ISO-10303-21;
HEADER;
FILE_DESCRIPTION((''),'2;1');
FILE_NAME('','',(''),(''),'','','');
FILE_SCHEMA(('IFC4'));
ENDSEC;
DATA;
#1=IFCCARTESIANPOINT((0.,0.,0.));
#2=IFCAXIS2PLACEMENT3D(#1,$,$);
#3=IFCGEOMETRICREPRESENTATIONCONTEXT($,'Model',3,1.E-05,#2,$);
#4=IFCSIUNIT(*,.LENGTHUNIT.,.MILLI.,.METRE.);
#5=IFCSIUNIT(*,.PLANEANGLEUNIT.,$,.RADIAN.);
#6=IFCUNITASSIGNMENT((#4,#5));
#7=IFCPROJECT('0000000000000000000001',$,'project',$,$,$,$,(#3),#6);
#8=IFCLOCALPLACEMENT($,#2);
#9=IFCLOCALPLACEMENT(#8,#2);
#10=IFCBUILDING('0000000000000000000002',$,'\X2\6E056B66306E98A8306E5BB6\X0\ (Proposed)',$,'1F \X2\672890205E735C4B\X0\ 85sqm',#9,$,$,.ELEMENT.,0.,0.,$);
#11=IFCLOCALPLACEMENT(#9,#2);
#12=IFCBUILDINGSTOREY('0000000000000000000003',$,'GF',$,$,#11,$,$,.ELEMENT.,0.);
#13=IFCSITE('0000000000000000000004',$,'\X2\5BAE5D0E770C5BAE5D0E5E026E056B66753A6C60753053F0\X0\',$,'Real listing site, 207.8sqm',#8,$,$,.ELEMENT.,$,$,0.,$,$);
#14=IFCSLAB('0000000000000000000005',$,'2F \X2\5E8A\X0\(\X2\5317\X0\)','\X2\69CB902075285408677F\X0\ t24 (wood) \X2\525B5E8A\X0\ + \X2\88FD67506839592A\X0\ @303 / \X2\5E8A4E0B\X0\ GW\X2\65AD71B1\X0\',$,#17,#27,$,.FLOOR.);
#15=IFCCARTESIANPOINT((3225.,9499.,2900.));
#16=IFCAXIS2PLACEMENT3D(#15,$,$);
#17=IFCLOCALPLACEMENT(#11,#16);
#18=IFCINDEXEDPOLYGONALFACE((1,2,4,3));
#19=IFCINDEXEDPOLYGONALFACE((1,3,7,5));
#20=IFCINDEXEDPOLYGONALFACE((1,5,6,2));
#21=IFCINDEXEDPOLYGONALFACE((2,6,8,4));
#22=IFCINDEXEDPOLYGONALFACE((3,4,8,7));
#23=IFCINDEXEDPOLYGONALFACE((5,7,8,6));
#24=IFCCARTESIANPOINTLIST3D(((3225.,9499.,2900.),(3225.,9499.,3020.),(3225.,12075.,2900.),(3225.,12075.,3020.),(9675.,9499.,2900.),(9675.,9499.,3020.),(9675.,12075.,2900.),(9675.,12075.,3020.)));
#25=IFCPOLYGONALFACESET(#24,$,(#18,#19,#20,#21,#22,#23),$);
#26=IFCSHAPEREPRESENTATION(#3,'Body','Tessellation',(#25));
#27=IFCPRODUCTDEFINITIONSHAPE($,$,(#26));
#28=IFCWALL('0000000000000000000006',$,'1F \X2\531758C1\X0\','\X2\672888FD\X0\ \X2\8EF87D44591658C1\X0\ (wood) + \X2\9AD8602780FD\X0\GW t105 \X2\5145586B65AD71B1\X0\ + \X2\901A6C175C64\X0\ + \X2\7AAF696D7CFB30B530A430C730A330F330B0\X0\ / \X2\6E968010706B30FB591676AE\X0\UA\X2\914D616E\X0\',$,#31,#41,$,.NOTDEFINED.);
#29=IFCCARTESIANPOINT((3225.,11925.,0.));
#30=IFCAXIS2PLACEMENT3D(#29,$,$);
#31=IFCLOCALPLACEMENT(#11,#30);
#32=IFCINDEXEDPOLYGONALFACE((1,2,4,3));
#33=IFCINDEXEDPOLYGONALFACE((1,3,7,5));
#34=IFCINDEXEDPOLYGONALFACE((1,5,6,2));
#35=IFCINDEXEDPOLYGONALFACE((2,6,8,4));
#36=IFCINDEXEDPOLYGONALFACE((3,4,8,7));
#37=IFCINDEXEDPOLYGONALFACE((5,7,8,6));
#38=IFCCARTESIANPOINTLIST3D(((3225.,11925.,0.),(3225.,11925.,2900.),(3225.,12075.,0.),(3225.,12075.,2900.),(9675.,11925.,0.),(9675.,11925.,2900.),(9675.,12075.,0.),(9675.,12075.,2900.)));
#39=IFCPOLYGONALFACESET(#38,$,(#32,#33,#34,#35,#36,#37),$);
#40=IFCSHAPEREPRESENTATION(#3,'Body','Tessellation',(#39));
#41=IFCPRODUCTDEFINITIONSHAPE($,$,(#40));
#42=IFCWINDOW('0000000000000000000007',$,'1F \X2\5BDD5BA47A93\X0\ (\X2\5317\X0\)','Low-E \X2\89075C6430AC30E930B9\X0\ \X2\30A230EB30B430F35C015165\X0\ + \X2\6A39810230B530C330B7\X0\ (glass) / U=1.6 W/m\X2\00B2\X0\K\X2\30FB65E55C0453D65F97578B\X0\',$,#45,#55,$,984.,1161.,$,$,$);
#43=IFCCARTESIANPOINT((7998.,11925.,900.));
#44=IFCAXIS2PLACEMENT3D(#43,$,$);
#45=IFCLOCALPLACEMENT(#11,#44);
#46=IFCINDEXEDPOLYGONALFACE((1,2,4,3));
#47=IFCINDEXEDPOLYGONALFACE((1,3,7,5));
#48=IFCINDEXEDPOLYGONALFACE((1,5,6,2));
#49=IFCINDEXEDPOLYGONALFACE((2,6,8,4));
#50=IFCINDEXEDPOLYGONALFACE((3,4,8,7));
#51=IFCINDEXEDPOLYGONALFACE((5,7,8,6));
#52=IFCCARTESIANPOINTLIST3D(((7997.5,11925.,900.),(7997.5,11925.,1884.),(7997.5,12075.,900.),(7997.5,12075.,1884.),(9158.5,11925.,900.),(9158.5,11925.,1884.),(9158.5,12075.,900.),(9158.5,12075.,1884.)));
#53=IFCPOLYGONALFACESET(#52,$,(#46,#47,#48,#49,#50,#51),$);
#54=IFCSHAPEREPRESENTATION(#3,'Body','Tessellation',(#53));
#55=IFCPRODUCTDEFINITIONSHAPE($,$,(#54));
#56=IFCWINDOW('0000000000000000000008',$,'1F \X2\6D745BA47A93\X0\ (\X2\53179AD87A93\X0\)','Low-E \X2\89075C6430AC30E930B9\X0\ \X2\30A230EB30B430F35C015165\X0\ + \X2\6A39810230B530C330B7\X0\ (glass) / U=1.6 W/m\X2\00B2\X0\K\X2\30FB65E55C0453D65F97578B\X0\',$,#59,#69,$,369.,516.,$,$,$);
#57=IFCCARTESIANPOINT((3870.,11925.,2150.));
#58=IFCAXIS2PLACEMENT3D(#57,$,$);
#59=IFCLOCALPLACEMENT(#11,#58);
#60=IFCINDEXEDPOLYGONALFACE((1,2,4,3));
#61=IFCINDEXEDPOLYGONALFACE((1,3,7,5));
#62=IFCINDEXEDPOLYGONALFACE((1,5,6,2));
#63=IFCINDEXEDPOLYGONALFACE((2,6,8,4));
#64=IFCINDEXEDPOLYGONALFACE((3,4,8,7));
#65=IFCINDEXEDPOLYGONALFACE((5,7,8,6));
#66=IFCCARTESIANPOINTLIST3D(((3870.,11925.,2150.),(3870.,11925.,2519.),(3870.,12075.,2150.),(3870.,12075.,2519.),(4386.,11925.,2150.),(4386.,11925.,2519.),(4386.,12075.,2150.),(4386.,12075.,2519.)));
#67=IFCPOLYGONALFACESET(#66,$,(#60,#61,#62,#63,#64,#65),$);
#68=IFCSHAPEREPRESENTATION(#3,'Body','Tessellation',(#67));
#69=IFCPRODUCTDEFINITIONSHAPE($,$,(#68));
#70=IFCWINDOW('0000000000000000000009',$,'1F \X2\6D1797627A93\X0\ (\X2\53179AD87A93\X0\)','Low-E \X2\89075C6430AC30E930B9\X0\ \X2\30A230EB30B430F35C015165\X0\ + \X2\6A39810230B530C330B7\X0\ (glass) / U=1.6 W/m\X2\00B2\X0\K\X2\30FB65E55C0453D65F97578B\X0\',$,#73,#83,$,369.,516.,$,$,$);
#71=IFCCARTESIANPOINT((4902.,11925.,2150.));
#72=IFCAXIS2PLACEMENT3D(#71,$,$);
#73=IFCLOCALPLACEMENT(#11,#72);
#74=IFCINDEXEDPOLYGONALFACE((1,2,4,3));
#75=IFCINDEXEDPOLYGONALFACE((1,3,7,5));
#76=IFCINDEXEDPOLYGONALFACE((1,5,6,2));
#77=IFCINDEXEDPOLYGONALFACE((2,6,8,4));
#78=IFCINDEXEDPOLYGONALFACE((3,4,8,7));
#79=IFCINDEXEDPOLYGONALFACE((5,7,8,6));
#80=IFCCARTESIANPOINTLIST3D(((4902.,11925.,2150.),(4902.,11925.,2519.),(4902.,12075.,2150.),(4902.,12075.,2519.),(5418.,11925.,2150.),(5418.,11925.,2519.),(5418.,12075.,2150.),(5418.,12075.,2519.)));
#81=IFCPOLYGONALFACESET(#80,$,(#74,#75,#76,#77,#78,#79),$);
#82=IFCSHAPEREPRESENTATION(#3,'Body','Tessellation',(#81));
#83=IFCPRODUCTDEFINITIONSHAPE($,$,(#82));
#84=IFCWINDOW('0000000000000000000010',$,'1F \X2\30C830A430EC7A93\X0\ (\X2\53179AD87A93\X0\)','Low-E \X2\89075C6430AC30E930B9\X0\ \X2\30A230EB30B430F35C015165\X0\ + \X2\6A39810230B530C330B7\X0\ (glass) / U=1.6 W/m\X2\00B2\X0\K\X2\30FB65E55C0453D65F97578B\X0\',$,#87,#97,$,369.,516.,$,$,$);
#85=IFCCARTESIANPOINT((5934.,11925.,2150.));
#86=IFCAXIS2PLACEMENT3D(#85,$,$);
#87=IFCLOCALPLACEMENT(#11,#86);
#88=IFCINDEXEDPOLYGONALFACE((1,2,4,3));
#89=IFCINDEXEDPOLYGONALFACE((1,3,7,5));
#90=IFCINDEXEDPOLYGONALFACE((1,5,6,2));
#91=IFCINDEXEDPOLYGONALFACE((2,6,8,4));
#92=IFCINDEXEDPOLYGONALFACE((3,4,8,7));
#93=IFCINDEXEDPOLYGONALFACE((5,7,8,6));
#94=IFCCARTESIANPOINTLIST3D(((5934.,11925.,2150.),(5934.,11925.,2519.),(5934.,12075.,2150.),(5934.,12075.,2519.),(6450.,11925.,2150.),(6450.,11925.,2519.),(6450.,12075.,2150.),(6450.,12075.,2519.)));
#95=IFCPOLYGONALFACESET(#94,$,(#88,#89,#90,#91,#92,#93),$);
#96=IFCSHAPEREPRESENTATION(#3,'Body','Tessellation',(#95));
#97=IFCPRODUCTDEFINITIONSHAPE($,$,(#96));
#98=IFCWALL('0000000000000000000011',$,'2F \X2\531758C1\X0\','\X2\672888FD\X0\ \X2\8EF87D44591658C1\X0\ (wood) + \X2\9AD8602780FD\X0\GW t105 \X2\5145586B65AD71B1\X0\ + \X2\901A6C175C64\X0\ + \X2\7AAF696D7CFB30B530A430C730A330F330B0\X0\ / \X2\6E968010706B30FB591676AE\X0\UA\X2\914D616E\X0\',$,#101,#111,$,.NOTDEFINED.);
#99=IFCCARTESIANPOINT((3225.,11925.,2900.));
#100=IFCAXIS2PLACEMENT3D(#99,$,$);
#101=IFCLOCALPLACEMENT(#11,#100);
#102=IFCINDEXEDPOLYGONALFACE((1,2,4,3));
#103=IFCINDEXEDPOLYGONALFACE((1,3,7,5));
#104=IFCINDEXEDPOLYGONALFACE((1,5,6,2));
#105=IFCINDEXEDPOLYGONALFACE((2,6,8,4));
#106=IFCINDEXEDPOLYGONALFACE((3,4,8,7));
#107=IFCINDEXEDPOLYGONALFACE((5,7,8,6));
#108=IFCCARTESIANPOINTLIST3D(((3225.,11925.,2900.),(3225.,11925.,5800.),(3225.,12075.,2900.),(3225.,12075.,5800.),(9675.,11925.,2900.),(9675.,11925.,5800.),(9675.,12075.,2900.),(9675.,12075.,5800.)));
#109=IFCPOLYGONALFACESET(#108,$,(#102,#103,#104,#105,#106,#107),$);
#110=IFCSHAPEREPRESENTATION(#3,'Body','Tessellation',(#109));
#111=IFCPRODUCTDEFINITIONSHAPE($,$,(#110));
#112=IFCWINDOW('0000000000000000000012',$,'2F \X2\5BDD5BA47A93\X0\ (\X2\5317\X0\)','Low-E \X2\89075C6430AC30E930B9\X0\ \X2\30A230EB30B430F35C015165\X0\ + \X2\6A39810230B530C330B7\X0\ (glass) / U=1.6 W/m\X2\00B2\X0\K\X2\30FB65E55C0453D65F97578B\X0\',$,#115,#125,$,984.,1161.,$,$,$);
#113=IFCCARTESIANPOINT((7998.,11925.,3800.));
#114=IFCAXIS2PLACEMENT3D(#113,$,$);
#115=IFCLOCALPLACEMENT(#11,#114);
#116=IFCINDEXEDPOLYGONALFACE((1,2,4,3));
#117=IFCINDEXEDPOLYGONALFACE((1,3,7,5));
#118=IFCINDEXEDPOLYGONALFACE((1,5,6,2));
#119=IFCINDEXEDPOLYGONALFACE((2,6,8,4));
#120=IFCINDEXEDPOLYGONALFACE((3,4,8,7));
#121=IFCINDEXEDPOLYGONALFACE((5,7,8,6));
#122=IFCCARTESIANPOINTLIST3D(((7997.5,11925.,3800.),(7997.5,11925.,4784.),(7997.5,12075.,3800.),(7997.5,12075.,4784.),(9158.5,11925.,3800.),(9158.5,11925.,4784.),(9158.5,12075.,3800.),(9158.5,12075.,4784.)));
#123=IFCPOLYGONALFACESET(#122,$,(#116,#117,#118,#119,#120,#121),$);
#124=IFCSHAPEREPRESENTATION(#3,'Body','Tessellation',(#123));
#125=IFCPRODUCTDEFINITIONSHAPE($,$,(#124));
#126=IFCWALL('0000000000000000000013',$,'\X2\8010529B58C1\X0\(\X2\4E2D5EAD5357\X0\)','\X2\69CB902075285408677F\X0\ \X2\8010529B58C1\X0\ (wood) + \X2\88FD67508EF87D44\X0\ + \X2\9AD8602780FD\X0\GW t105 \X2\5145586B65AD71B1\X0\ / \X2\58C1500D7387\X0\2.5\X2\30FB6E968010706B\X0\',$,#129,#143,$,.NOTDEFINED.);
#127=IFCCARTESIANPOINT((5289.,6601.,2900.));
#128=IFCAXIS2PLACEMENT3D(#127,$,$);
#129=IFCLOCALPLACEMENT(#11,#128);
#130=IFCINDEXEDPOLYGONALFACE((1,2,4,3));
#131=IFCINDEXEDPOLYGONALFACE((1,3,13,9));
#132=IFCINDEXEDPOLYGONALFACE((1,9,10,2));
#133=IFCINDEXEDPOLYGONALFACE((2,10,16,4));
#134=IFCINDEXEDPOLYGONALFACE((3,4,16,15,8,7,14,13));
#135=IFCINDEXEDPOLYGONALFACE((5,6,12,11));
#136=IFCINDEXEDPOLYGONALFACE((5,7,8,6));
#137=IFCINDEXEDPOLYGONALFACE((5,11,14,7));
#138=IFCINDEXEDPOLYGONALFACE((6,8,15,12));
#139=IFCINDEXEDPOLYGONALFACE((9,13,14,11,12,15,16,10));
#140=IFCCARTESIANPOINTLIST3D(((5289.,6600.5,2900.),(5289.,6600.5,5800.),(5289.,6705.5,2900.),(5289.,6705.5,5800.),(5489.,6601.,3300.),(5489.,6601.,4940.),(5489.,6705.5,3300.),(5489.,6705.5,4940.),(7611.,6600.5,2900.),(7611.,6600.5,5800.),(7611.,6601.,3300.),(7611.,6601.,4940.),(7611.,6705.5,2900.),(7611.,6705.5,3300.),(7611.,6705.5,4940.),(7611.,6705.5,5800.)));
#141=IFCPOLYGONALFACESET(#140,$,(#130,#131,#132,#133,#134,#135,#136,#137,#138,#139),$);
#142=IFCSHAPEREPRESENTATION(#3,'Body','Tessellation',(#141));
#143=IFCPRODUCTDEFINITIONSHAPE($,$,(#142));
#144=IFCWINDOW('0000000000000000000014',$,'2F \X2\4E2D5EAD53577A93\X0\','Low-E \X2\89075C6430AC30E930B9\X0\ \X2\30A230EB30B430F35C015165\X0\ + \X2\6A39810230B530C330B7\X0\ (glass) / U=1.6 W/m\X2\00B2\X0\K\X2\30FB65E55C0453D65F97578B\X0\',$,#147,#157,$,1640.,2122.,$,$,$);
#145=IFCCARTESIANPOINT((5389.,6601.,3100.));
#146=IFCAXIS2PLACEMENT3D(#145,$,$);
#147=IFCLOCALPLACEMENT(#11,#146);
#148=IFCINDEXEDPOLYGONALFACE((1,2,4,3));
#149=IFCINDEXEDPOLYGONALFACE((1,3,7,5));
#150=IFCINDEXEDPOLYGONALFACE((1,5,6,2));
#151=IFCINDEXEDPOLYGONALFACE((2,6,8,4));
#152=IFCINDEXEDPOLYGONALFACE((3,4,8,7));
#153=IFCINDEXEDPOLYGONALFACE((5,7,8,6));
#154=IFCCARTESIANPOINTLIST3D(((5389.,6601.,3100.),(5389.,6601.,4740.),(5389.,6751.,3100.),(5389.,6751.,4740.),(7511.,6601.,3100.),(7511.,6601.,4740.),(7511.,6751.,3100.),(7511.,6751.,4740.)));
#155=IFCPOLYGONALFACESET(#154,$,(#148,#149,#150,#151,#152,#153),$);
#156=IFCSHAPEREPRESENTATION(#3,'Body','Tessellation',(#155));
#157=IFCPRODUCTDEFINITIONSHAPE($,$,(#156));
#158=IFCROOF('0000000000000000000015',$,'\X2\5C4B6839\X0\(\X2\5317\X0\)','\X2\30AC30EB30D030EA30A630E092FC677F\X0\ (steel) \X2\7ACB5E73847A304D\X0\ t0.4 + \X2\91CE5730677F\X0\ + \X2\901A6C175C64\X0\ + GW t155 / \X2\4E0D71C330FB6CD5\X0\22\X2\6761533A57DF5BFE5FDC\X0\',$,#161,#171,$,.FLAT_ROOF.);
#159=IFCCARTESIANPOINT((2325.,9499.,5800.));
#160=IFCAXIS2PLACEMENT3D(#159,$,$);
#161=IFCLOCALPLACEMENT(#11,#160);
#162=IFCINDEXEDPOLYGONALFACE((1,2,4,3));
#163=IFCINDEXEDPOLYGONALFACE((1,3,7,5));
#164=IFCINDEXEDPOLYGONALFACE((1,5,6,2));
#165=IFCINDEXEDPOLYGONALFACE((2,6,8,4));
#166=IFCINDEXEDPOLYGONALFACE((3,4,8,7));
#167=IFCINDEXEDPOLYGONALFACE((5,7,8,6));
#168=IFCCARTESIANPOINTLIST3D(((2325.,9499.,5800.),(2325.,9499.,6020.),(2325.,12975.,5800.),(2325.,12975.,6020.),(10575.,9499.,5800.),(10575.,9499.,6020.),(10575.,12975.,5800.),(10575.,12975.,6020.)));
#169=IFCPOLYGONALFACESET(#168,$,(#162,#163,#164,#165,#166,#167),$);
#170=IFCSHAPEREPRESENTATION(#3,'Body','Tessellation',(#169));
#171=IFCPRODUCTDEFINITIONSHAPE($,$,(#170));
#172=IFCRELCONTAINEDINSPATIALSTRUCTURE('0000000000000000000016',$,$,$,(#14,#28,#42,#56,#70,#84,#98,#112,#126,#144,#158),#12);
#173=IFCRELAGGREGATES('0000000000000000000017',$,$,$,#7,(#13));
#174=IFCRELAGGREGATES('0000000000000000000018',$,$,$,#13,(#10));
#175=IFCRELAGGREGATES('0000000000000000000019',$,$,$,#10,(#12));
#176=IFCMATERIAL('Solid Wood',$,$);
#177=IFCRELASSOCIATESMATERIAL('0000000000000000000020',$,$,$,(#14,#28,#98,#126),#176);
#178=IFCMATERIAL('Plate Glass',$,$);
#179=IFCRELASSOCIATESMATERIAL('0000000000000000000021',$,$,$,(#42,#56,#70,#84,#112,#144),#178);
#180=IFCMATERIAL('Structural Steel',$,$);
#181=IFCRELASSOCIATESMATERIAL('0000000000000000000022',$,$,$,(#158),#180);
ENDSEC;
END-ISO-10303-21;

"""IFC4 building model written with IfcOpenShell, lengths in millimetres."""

from ifc_helpers import new_model, si_unit, frame, frame_2d, origin, place, context, project, spatial, rectangle, extrude, material, element, fill, save


model = new_model("IFC4")

# Units and contexts
model_context = context("Model", 3, precision=1e-05, world=origin())
ifc_project = project(units=[si_unit("LENGTHUNIT", "METRE", prefix="MILLI"), si_unit("PLANEANGLEUNIT", "RADIAN")], contexts=[model_context])

# Site, building, storey
site_placement = place(None, origin())
site = spatial("IfcSite", under=ifc_project, at=site_placement, Name="宮崎県宮崎市清武町池田台", ObjectType="Real listing site, 207.8sqm", CompositionType="ELEMENT", RefElevation=0.0)
building_placement = place(site_placement, origin())
building = spatial("IfcBuilding", under=site, at=building_placement, Name="清武の風の家 (Proposed)", ObjectType="1F 木造平屋 85sqm", CompositionType="ELEMENT", ElevationOfRefHeight=0.0, ElevationOfTerrain=0.0)
storey_placement = place(building_placement, origin())
storey = spatial("IfcBuildingStorey", under=building, at=storey_placement, Name="GF", CompositionType="ELEMENT", Elevation=0.0)

# Slab
ifc_material_1 = material(Name="Solid Wood")
slab_1_placement = place(storey_placement, frame((3225.0, 9499.0, 2900.0)))
element("IfcSlab", 1, at=slab_1_placement, inside=storey, material=ifc_material_1, Name="2F 床(北)", Description="構造用合板 t24 (wood) 剛床 + 製材根太 @303 / 床下 GW断熱", PredefinedType="FLOOR", context=model_context, shape_type="SweptSolid", body=[
    extrude(rectangle(XDim=6450.0, YDim=2576.0, at=frame_2d((3225.0, 1288.0))), frame((3225.0, 9499.0, 2900.0)), (0.0, 0.0, 1.0), 120.0),
])

# Wall, openings, windows
wall_1_placement = place(storey_placement, frame((3225.0, 11925.0, 0.0)))
wall_1 = element("IfcWall", 2, at=wall_1_placement, inside=storey, material=ifc_material_1, Name="1F 北壁", Description="木製 軸組外壁 (wood) + 高性能GW t105 充填断熱 + 通気層 + 窯業系サイディング / 準耐火・外皮UA配慮", PredefinedType="NOTDEFINED", context=model_context, shape_type="SweptSolid", body=[
    extrude(rectangle(XDim=6450.0, YDim=150.0, at=frame_2d((3225.0, 75.0))), frame((3225.0, 11925.0, 0.0)), (0.0, 0.0, 1.0), 2900.0),
])
opening_1_placement = place(storey_placement, frame((7998.0, 11925.0, 900.0)))
opening_1 = element("IfcOpeningElement", 3, at=opening_1_placement, cuts=wall_1, PredefinedType="NOTDEFINED", context=model_context, shape_type="SweptSolid", body=[
    extrude(rectangle(XDim=1161.0, YDim=150.0, at=frame_2d((580.0, 75.0))), frame((7998.0, 11925.0, 900.0)), (0.0, 0.0, 1.0), 984.0),
])
opening_2_placement = place(storey_placement, frame((3870.0, 11925.0, 2150.0)))
opening_2 = element("IfcOpeningElement", 4, at=opening_2_placement, cuts=wall_1, PredefinedType="NOTDEFINED", context=model_context, shape_type="SweptSolid", body=[
    extrude(rectangle(XDim=516.0, YDim=150.0, at=frame_2d((258.0, 75.0))), frame((3870.0, 11925.0, 2150.0)), (0.0, 0.0, 1.0), 369.0),
])
opening_3_placement = place(storey_placement, frame((4902.0, 11925.0, 2150.0)))
opening_3 = element("IfcOpeningElement", 5, at=opening_3_placement, cuts=wall_1, PredefinedType="NOTDEFINED", context=model_context, shape_type="SweptSolid", body=[
    extrude(rectangle(XDim=516.0, YDim=150.0, at=frame_2d((258.0, 75.0))), frame((4902.0, 11925.0, 2150.0)), (0.0, 0.0, 1.0), 369.0),
])
opening_4_placement = place(storey_placement, frame((5934.0, 11925.0, 2150.0)))
opening_4 = element("IfcOpeningElement", 6, at=opening_4_placement, cuts=wall_1, PredefinedType="NOTDEFINED", context=model_context, shape_type="SweptSolid", body=[
    extrude(rectangle(XDim=516.0, YDim=150.0, at=frame_2d((258.0, 75.0))), frame((5934.0, 11925.0, 2150.0)), (0.0, 0.0, 1.0), 369.0),
])
ifc_material_2 = material(Name="Plate Glass")
window_1_placement = place(storey_placement, frame((7998.0, 11925.0, 900.0)))
window_1 = element("IfcWindow", 7, at=window_1_placement, inside=storey, material=ifc_material_2, Name="1F 寝室窓 (北)", Description="Low-E 複層ガラス アルゴン封入 + 樹脂サッシ (glass) / U=1.6 W/m²K・日射取得型", OverallHeight=984.0, OverallWidth=1161.0, context=model_context, shape_type="SweptSolid", body=[
    extrude(rectangle(XDim=1161.0, YDim=150.0, at=frame_2d((580.0, 75.0))), frame((7998.0, 11925.0, 900.0)), (0.0, 0.0, 1.0), 984.0),
])
fill(opening_1, window_1)
window_2_placement = place(storey_placement, frame((3870.0, 11925.0, 2150.0)))
window_2 = element("IfcWindow", 8, at=window_2_placement, inside=storey, material=ifc_material_2, Name="1F 浴室窓 (北高窓)", Description="Low-E 複層ガラス アルゴン封入 + 樹脂サッシ (glass) / U=1.6 W/m²K・日射取得型", OverallHeight=369.0, OverallWidth=516.0, context=model_context, shape_type="SweptSolid", body=[
    extrude(rectangle(XDim=516.0, YDim=150.0, at=frame_2d((258.0, 75.0))), frame((3870.0, 11925.0, 2150.0)), (0.0, 0.0, 1.0), 369.0),
])
fill(opening_2, window_2)
window_3_placement = place(storey_placement, frame((4902.0, 11925.0, 2150.0)))
window_3 = element("IfcWindow", 9, at=window_3_placement, inside=storey, material=ifc_material_2, Name="1F 洗面窓 (北高窓)", Description="Low-E 複層ガラス アルゴン封入 + 樹脂サッシ (glass) / U=1.6 W/m²K・日射取得型", OverallHeight=369.0, OverallWidth=516.0, context=model_context, shape_type="SweptSolid", body=[
    extrude(rectangle(XDim=516.0, YDim=150.0, at=frame_2d((258.0, 75.0))), frame((4902.0, 11925.0, 2150.0)), (0.0, 0.0, 1.0), 369.0),
])
fill(opening_3, window_3)
window_4_placement = place(storey_placement, frame((5934.0, 11925.0, 2150.0)))
window_4 = element("IfcWindow", 10, at=window_4_placement, inside=storey, material=ifc_material_2, Name="1F トイレ窓 (北高窓)", Description="Low-E 複層ガラス アルゴン封入 + 樹脂サッシ (glass) / U=1.6 W/m²K・日射取得型", OverallHeight=369.0, OverallWidth=516.0, context=model_context, shape_type="SweptSolid", body=[
    extrude(rectangle(XDim=516.0, YDim=150.0, at=frame_2d((258.0, 75.0))), frame((5934.0, 11925.0, 2150.0)), (0.0, 0.0, 1.0), 369.0),
])
fill(opening_4, window_4)

# Walls, openings, windows
wall_2_placement = place(storey_placement, frame((3225.0, 11925.0, 2900.0)))
wall_2 = element("IfcWall", 11, at=wall_2_placement, inside=storey, material=ifc_material_1, Name="2F 北壁", Description="木製 軸組外壁 (wood) + 高性能GW t105 充填断熱 + 通気層 + 窯業系サイディング / 準耐火・外皮UA配慮", PredefinedType="NOTDEFINED", context=model_context, shape_type="SweptSolid", body=[
    extrude(rectangle(XDim=6450.0, YDim=150.0, at=frame_2d((3225.0, 75.0))), frame((3225.0, 11925.0, 2900.0)), (0.0, 0.0, 1.0), 2900.0),
])
opening_5_placement = place(storey_placement, frame((7998.0, 11925.0, 3800.0)))
opening_5 = element("IfcOpeningElement", 12, at=opening_5_placement, cuts=wall_2, PredefinedType="NOTDEFINED", context=model_context, shape_type="SweptSolid", body=[
    extrude(rectangle(XDim=1161.0, YDim=150.0, at=frame_2d((580.0, 75.0))), frame((7998.0, 11925.0, 3800.0)), (0.0, 0.0, 1.0), 984.0),
])
window_5_placement = place(storey_placement, frame((7998.0, 11925.0, 3800.0)))
window_5 = element("IfcWindow", 13, at=window_5_placement, inside=storey, material=ifc_material_2, Name="2F 寝室窓 (北)", Description="Low-E 複層ガラス アルゴン封入 + 樹脂サッシ (glass) / U=1.6 W/m²K・日射取得型", OverallHeight=984.0, OverallWidth=1161.0, context=model_context, shape_type="SweptSolid", body=[
    extrude(rectangle(XDim=1161.0, YDim=150.0, at=frame_2d((580.0, 75.0))), frame((7998.0, 11925.0, 3800.0)), (0.0, 0.0, 1.0), 984.0),
])
fill(opening_5, window_5)
wall_3_placement = place(storey_placement, frame((5289.0, 6601.0, 2900.0)))
wall_3 = element("IfcWall", 14, at=wall_3_placement, inside=storey, material=ifc_material_1, Name="耐力壁(中庭南)", Description="構造用合板 耐力壁 (wood) + 製材軸組 + 高性能GW t105 充填断熱 / 壁倍率2.5・準耐火", PredefinedType="NOTDEFINED", context=model_context, shape_type="SweptSolid", body=[
    extrude(rectangle(XDim=2322.0, YDim=105.0, at=frame_2d((1161.0, 52.0))), frame((5289.0, 6601.0, 2900.0)), (0.0, 0.0, 1.0), 2900.0),
])
opening_6_placement = place(storey_placement, frame((5389.0, 6601.0, 3100.0)))
opening_6 = element("IfcOpeningElement", 15, at=opening_6_placement, cuts=wall_3, PredefinedType="NOTDEFINED", context=model_context, shape_type="SweptSolid", body=[
    extrude(rectangle(XDim=2122.0, YDim=150.0, at=frame_2d((1061.0, 75.0))), frame((5389.0, 6601.0, 3100.0)), (0.0, 0.0, 1.0), 1640.0),
])
window_6_placement = place(storey_placement, frame((5389.0, 6601.0, 3100.0)))
window_6 = element("IfcWindow", 16, at=window_6_placement, inside=storey, material=ifc_material_2, Name="2F 中庭南窓", Description="Low-E 複層ガラス アルゴン封入 + 樹脂サッシ (glass) / U=1.6 W/m²K・日射取得型", OverallHeight=1640.0, OverallWidth=2122.0, context=model_context, shape_type="SweptSolid", body=[
    extrude(rectangle(XDim=2122.0, YDim=150.0, at=frame_2d((1061.0, 75.0))), frame((5389.0, 6601.0, 3100.0)), (0.0, 0.0, 1.0), 1640.0),
])
fill(opening_6, window_6)

# Roof
ifc_material_3 = material(Name="Structural Steel")
for number, where, name in (
    (17, (2325.0, 9499.0, 5800.0), "屋根(北)"),
):
    element("IfcRoof", number, at=place(storey_placement, frame(where)), inside=storey, material=ifc_material_3, Name=name, Description="ガルバリウム鋼板 (steel) 立平葺き t0.4 + 野地板 + 通気層 + GW t155 / 不燃・法22条区域対応", PredefinedType="FLAT_ROOF", context=model_context, shape_type="SweptSolid", body=[
        extrude(rectangle(XDim=8250.0, YDim=3476.0, at=frame_2d((4125.0, 1738.0))), frame((2325.0, 9499.0, 5800.0)), (0.0, 0.0, 1.0), 220.0),
    ])

save(model, "model.ifc")
